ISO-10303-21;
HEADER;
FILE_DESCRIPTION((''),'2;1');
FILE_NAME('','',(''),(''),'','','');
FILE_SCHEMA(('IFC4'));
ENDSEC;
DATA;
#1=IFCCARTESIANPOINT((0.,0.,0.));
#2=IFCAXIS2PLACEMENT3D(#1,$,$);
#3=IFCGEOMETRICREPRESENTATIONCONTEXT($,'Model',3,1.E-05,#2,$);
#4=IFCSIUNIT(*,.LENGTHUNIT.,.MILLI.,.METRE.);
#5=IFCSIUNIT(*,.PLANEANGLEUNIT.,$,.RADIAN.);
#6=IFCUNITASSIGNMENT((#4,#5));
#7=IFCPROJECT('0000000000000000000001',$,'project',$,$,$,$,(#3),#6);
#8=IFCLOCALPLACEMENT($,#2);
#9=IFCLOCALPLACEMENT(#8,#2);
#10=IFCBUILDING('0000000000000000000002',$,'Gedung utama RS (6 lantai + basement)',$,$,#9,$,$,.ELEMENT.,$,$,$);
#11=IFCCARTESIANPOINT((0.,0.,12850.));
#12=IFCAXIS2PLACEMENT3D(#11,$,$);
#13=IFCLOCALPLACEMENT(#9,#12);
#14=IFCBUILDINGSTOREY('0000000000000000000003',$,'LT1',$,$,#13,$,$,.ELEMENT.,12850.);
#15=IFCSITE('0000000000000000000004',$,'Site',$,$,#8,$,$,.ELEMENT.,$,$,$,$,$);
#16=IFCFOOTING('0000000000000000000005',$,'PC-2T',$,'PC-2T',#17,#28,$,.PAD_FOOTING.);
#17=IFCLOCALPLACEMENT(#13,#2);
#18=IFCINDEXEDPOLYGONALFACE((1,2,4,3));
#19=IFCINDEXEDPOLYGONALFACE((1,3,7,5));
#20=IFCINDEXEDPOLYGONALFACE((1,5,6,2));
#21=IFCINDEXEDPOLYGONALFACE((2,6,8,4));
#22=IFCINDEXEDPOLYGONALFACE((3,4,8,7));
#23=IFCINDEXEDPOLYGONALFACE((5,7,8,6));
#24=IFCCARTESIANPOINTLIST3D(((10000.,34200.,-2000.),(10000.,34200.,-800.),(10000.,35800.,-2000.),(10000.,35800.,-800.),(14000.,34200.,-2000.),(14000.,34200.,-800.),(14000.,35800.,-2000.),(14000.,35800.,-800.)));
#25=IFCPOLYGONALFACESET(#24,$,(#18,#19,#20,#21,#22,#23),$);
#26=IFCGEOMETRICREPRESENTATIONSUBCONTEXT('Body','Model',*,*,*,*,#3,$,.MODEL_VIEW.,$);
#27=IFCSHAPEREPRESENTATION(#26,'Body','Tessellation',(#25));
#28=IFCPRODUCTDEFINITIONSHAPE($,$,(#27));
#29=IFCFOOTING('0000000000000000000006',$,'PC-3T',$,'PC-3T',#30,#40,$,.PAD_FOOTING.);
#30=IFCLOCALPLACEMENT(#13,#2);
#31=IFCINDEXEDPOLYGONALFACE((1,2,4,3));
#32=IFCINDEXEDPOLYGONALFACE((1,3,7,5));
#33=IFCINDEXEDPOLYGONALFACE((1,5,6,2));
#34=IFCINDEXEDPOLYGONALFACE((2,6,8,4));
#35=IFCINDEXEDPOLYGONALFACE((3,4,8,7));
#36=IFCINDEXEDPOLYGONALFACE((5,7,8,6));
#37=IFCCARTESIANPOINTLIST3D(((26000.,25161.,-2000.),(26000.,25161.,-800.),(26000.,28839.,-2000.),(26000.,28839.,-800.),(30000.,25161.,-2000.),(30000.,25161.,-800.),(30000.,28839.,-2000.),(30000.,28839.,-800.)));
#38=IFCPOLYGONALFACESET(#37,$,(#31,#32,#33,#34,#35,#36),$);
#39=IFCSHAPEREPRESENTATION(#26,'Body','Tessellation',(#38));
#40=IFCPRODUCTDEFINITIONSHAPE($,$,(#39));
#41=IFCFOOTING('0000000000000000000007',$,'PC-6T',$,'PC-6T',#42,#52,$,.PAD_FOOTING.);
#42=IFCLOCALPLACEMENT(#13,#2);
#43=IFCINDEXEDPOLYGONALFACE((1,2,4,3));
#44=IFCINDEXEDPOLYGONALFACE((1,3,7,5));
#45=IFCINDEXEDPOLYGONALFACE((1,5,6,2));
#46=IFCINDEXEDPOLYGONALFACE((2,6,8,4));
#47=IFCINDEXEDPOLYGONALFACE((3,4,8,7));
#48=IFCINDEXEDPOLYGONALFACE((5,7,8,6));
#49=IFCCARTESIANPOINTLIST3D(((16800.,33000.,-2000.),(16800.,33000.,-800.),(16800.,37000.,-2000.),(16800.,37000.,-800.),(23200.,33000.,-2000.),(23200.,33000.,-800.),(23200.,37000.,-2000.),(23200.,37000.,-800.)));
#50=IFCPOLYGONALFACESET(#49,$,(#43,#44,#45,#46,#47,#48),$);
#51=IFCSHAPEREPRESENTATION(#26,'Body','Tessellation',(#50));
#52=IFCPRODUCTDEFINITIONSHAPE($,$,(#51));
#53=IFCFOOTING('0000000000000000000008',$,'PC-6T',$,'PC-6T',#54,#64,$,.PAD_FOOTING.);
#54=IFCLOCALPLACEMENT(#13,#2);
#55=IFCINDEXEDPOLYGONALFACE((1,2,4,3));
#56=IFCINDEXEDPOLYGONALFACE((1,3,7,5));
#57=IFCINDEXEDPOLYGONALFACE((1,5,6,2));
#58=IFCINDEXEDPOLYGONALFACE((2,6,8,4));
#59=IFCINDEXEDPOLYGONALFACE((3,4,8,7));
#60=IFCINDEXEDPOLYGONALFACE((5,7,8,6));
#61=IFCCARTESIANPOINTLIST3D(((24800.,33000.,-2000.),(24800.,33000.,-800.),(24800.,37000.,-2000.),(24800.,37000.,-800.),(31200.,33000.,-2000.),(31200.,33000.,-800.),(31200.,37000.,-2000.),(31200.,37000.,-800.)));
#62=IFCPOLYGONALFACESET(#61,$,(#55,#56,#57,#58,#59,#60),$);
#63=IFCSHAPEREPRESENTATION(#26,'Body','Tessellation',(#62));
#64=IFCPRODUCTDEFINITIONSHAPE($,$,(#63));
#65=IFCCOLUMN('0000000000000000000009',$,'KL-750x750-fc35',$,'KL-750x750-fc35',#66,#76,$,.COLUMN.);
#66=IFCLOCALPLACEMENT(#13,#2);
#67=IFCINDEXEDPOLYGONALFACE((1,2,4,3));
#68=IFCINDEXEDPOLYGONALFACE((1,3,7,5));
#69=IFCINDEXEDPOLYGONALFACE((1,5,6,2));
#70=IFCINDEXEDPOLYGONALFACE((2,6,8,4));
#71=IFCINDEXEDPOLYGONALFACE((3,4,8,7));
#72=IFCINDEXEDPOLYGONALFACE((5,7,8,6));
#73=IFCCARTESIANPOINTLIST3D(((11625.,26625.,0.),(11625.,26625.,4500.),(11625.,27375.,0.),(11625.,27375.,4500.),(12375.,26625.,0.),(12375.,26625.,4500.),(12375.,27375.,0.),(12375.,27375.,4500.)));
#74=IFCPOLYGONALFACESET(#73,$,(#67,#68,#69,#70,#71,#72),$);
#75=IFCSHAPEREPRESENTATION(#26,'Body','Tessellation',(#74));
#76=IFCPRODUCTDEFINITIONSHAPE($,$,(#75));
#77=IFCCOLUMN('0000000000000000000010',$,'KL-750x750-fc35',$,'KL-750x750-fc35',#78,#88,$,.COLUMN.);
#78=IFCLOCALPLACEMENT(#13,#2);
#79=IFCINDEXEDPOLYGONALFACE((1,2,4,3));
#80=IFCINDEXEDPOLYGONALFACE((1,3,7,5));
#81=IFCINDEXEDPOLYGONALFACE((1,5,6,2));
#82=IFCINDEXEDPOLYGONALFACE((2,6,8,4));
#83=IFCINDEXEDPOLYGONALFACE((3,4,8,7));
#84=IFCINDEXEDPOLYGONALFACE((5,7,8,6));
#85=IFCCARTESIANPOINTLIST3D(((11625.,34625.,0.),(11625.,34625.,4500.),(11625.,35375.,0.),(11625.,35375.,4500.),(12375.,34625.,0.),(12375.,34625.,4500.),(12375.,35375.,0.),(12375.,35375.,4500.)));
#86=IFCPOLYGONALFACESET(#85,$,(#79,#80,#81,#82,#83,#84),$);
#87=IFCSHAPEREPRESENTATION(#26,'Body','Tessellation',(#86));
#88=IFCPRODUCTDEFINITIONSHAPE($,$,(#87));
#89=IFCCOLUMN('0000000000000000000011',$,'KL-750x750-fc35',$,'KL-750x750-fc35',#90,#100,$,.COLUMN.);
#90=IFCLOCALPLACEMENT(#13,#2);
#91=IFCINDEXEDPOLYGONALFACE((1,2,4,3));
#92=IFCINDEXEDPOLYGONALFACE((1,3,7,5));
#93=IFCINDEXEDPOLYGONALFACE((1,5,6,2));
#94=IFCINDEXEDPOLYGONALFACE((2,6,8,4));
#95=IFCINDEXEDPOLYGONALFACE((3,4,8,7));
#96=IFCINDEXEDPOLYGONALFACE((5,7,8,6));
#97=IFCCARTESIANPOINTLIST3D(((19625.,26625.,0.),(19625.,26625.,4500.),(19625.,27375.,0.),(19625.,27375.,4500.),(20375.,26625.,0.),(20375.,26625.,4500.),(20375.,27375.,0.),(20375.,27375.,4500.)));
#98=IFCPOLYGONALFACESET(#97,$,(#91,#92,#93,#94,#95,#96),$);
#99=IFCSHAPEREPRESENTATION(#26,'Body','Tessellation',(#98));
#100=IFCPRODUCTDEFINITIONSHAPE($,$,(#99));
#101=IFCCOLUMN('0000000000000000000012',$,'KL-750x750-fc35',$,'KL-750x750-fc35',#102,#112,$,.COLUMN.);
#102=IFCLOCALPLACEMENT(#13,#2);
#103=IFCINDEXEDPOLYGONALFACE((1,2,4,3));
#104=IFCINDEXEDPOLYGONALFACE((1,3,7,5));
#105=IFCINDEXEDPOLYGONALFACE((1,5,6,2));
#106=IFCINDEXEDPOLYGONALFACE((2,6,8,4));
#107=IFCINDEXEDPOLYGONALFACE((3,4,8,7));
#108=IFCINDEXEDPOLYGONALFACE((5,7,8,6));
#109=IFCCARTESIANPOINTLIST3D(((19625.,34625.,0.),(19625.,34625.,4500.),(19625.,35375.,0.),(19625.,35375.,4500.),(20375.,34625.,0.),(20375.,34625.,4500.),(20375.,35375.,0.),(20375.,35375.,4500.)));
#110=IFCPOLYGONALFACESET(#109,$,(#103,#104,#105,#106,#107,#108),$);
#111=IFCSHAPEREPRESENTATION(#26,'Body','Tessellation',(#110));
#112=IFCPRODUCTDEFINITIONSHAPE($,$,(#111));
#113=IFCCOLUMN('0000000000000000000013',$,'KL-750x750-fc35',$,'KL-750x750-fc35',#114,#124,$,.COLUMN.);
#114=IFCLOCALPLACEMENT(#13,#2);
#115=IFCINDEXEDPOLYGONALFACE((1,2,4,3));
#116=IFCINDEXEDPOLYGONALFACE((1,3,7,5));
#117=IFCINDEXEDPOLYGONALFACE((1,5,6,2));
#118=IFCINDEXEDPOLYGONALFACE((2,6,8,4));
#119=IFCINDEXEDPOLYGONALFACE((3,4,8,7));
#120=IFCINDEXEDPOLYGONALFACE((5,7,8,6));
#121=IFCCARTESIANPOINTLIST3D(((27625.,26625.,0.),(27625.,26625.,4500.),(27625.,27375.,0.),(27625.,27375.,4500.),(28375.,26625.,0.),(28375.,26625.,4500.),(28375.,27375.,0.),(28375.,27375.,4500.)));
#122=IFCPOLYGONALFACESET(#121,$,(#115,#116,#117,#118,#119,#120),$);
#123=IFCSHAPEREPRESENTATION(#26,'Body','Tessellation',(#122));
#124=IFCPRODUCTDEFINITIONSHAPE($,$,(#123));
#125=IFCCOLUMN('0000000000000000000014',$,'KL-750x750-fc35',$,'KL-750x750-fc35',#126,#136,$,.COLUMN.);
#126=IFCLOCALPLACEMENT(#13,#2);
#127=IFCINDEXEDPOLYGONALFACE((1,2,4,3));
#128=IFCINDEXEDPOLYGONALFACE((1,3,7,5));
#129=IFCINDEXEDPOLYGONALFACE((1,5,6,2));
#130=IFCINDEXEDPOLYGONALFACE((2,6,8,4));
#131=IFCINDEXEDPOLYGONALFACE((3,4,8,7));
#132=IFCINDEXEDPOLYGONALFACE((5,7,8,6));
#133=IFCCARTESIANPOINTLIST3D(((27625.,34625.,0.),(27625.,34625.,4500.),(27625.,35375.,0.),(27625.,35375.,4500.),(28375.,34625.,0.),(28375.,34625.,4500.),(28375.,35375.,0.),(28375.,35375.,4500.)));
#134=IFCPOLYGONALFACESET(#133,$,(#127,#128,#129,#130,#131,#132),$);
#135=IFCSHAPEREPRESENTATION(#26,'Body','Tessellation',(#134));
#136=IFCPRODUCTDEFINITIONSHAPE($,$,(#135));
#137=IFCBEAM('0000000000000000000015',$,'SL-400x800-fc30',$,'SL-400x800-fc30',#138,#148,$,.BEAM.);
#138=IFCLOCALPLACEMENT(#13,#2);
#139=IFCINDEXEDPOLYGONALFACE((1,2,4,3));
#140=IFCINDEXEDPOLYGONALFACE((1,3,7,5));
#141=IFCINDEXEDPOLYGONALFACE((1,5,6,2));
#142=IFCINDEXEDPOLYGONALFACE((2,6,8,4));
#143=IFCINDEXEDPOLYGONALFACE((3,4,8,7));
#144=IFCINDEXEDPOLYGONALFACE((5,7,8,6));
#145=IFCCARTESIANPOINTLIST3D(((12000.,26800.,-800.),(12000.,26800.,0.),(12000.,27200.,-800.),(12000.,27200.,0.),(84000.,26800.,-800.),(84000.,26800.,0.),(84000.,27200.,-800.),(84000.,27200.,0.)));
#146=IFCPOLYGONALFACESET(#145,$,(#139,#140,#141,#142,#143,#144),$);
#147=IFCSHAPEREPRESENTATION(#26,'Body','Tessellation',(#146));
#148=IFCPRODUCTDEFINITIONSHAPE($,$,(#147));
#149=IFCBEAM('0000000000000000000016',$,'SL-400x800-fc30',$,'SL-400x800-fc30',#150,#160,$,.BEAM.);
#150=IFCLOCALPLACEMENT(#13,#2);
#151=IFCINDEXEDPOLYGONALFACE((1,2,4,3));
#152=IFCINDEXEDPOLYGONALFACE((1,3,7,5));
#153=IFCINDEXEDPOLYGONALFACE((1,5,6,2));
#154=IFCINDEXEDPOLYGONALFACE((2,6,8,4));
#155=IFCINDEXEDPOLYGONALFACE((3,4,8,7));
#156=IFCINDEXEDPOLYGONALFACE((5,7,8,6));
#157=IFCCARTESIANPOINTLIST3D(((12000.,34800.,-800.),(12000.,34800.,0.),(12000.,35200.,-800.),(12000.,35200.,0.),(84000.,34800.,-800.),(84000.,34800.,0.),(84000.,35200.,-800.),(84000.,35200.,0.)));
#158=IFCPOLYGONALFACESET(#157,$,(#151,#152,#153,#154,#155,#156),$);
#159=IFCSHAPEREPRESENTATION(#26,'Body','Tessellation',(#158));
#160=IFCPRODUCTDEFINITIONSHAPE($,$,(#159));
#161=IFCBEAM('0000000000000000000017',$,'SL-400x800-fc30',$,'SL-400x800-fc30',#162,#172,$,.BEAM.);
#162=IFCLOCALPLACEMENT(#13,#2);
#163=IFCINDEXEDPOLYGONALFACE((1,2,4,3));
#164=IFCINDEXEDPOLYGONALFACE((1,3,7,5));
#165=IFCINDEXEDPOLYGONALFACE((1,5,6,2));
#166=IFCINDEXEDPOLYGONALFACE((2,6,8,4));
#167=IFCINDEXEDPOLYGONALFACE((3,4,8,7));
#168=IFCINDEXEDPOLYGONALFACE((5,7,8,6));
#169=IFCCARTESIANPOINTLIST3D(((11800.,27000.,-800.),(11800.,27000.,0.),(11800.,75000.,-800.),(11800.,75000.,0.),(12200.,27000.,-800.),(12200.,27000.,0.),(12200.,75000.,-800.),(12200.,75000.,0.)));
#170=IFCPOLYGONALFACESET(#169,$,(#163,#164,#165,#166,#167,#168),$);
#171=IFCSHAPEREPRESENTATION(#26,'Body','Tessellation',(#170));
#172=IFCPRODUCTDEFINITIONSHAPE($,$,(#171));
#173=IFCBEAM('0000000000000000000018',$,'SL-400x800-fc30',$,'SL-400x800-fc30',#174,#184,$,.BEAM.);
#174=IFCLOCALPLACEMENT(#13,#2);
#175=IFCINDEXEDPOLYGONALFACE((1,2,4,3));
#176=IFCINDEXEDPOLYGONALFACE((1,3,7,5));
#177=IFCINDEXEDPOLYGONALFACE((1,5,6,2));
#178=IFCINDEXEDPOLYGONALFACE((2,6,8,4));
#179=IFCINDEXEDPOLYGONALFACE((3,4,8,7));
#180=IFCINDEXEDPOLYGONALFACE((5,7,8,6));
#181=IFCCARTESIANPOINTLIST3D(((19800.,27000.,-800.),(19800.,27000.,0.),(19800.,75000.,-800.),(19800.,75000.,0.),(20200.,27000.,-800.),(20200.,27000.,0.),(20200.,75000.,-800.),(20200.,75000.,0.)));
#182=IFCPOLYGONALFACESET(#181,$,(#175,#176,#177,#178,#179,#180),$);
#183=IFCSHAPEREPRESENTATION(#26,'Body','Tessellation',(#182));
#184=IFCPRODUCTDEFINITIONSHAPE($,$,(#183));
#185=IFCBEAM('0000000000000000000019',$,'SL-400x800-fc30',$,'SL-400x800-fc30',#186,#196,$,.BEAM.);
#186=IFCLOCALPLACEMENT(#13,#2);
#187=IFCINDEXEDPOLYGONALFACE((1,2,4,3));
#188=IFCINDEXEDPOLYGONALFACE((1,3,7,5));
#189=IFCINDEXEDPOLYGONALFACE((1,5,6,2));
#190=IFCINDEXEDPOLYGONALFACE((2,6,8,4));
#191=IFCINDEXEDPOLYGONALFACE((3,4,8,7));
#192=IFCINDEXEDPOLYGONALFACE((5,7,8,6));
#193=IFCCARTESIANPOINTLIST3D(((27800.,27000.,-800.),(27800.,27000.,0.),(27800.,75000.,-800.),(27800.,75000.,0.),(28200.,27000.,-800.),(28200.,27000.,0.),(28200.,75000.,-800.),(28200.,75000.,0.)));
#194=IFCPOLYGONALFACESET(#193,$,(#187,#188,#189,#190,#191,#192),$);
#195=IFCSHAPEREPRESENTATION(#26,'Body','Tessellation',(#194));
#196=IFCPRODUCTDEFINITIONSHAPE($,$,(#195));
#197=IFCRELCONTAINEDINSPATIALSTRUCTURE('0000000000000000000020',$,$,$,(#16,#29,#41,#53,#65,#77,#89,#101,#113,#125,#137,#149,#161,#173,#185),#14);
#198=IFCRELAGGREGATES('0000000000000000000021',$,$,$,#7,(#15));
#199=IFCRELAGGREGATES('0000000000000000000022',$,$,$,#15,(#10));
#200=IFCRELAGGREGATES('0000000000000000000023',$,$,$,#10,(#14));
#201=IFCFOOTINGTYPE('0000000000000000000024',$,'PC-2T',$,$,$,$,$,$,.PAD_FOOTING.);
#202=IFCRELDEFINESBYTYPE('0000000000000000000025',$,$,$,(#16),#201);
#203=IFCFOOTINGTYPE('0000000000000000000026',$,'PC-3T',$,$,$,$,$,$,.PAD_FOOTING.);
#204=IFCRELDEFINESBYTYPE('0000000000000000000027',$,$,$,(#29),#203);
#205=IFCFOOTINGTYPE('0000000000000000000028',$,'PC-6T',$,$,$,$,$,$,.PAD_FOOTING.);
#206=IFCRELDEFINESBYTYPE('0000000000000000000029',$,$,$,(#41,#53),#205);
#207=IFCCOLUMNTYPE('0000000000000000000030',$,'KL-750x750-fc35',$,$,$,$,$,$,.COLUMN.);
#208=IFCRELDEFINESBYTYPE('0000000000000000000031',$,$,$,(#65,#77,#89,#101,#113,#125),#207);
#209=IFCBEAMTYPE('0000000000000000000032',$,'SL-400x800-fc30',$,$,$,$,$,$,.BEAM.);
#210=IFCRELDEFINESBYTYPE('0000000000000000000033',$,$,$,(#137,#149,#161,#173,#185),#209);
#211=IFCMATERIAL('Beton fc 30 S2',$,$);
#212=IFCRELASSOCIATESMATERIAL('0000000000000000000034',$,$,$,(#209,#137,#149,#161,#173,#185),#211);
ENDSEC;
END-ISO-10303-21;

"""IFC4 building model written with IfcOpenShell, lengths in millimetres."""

from ifc_helpers import new_model, si_unit, frame, origin, origin_2d, place, context, subcontext, project, spatial, rectangle, extrude, material, material_profile, profile_set, profile_usage, type_object, element, save


model = new_model("IFC4")

# Units and contexts
model_context = context("Model", 3, precision=1e-05, world=origin())
body_context = subcontext(model_context, "Body", "Model", "MODEL_VIEW")
ifc_project = project(units=[si_unit("LENGTHUNIT", "METRE", prefix="MILLI"), si_unit("PLANEANGLEUNIT", "RADIAN")], contexts=[model_context])

# Site, building, storey
site_placement = place(None, origin())
site = spatial("IfcSite", under=ifc_project, at=site_placement, Name="Site", CompositionType="ELEMENT")
building_placement = place(site_placement, origin())
building = spatial("IfcBuilding", under=site, at=building_placement, Name="Gedung utama RS (6 lantai + basement)", CompositionType="ELEMENT")
storey_placement = place(building_placement, frame((0.0, 0.0, 12850.0)))
storey = spatial("IfcBuildingStorey", under=building, at=storey_placement, Name="LT1", CompositionType="ELEMENT", Elevation=12850.0)

# Footings
ifc_material_profile_1 = material_profile(None, rectangle(XDim=4000.0, YDim=1600.0, at=origin_2d()), Name="PC-2T")
ifc_profile_set_1 = profile_set([ifc_material_profile_1], Name="PC-2T")
ifc_profile_usage_1 = profile_usage(ifc_profile_set_1, cardinal=5)
footing_type_1 = type_object("IfcFootingType", Name="PC-2T", PredefinedType="PAD_FOOTING", material=ifc_profile_set_1)
footing_1_placement = place(storey_placement, frame((12000.0, 35000.0, -2000.0), z_axis=(0.0, 0.0, 1.0), x_axis=(1.0, 0.0, 0.0)))
element("IfcFooting", 1, at=footing_1_placement, inside=storey, type_object=footing_type_1, material=ifc_profile_usage_1, Name="PC-2T", ObjectType="PC-2T", PredefinedType="PAD_FOOTING", context=body_context, shape_type="SweptSolid", body=[
    extrude(rectangle(XDim=4000.0, YDim=1600.0, at=origin_2d()), origin(), (0.0, 0.0, 1.0), 1200.0),
])
ifc_material_profile_2 = material_profile(None, rectangle(XDim=4000.0, YDim=3678.0, at=origin_2d()), Name="PC-3T")
ifc_profile_set_2 = profile_set([ifc_material_profile_2], Name="PC-3T")
ifc_profile_usage_2 = profile_usage(ifc_profile_set_2, cardinal=5)
footing_type_2 = type_object("IfcFootingType", Name="PC-3T", PredefinedType="PAD_FOOTING", material=ifc_profile_set_2)
footing_2_placement = place(storey_placement, frame((28000.0, 27000.0, -2000.0), z_axis=(0.0, 0.0, 1.0), x_axis=(1.0, 0.0, 0.0)))
element("IfcFooting", 2, at=footing_2_placement, inside=storey, type_object=footing_type_2, material=ifc_profile_usage_2, Name="PC-3T", ObjectType="PC-3T", PredefinedType="PAD_FOOTING", context=body_context, shape_type="SweptSolid", body=[
    extrude(rectangle(XDim=4000.0, YDim=3678.0, at=origin_2d()), origin(), (0.0, 0.0, 1.0), 1200.0),
])
ifc_material_profile_3 = material_profile(None, rectangle(XDim=6400.0, YDim=4000.0, at=origin_2d()), Name="PC-6T")
ifc_profile_set_3 = profile_set([ifc_material_profile_3], Name="PC-6T")
ifc_profile_usage_3 = profile_usage(ifc_profile_set_3, cardinal=5)
footing_type_3 = type_object("IfcFootingType", Name="PC-6T", PredefinedType="PAD_FOOTING", material=ifc_profile_set_3)
for number, where, z_axis, x_axis, name in (
    (3, (20000.0, 35000.0, -2000.0), (0.0, 0.0, 1.0), (1.0, 0.0, 0.0), "PC-6T"),
    (4, (28000.0, 35000.0, -2000.0), (0.0, 0.0, 1.0), (1.0, 0.0, 0.0), "PC-6T"),
):
    element("IfcFooting", number, at=place(storey_placement, frame(where, z_axis=z_axis, x_axis=x_axis)), inside=storey, type_object=footing_type_3, material=ifc_profile_usage_3, Name=name, ObjectType="PC-6T", PredefinedType="PAD_FOOTING", context=body_context, shape_type="SweptSolid", body=[
        extrude(rectangle(XDim=6400.0, YDim=4000.0, at=origin_2d()), origin(), (0.0, 0.0, 1.0), 1200.0),
    ])

# Columns
ifc_material_profile_4 = material_profile(None, rectangle(XDim=750.0, YDim=750.0, at=origin_2d()), Name="KL-750x750-fc35")
ifc_profile_set_4 = profile_set([ifc_material_profile_4], Name="KL-750x750-fc35")
ifc_profile_usage_4 = profile_usage(ifc_profile_set_4, cardinal=5)
column_type = type_object("IfcColumnType", Name="KL-750x750-fc35", PredefinedType="COLUMN", material=ifc_profile_set_4)
for number, where, z_axis, x_axis, name in (
    (5, (12000.0, 27000.0, 0.0), (0.0, 0.0, 1.0), (1.0, 0.0, 0.0), "KL-750x750-fc35"),
    (6, (12000.0, 35000.0, 0.0), (0.0, 0.0, 1.0), (1.0, 0.0, 0.0), "KL-750x750-fc35"),
    (7, (20000.0, 27000.0, 0.0), (0.0, 0.0, 1.0), (1.0, 0.0, 0.0), "KL-750x750-fc35"),
    (8, (20000.0, 35000.0, 0.0), (0.0, 0.0, 1.0), (1.0, 0.0, 0.0), "KL-750x750-fc35"),
    (9, (28000.0, 27000.0, 0.0), (0.0, 0.0, 1.0), (1.0, 0.0, 0.0), "KL-750x750-fc35"),
    (10, (28000.0, 35000.0, 0.0), (0.0, 0.0, 1.0), (1.0, 0.0, 0.0), "KL-750x750-fc35"),
):
    element("IfcColumn", number, at=place(storey_placement, frame(where, z_axis=z_axis, x_axis=x_axis)), inside=storey, type_object=column_type, material=ifc_profile_usage_4, Name=name, ObjectType="KL-750x750-fc35", PredefinedType="COLUMN", context=body_context, shape_type="SweptSolid", body=[
        extrude(rectangle(XDim=750.0, YDim=750.0, at=origin_2d()), origin(), (0.0, 0.0, 1.0), 4500.0),
    ])

# Beams
ifc_material_1 = material(Name="Beton fc 30 S2")
ifc_material_profile_5 = material_profile(ifc_material_1, rectangle(XDim=400.0, YDim=800.0, at=origin_2d()), Name="SL-400x800-fc30")
ifc_profile_set_5 = profile_set([ifc_material_profile_5], Name="SL-400x800-fc30")
ifc_profile_usage_5 = profile_usage(ifc_profile_set_5, cardinal=8)
beam_type = type_object("IfcBeamType", Name="SL-400x800-fc30", PredefinedType="BEAM", material=ifc_profile_set_5)
for number, where, name in (
    (11, (12000.0, 27000.0, -400.0), "SL-400x800-fc30"),
    (12, (12000.0, 35000.0, -400.0), "SL-400x800-fc30"),
):
    element("IfcBeam", number, at=place(storey_placement, frame(where)), inside=storey, type_object=beam_type, material=ifc_profile_usage_5, Name=name, ObjectType="SL-400x800-fc30", PredefinedType="BEAM", context=body_context, shape_type="SweptSolid", body=[
        extrude(rectangle(XDim=400.0, YDim=800.0, at=origin_2d()), frame((0.0, 0.0, 0.0), z_axis=(1.0, 0.0, 0.0), x_axis=(0.0, 1.0, 0.0)), (0.0, 0.0, 1.0), 72000.0),
    ])
for number, where, name in (
    (13, (12000.0, 27000.0, -400.0), "SL-400x800-fc30"),
    (14, (20000.0, 27000.0, -400.0), "SL-400x800-fc30"),
    (15, (28000.0, 27000.0, -400.0), "SL-400x800-fc30"),
):
    element("IfcBeam", number, at=place(storey_placement, frame(where)), inside=storey, type_object=beam_type, material=ifc_profile_usage_5, Name=name, ObjectType="SL-400x800-fc30", PredefinedType="BEAM", context=body_context, shape_type="SweptSolid", body=[
        extrude(rectangle(XDim=400.0, YDim=800.0, at=origin_2d()), frame((0.0, 0.0, 0.0), z_axis=(0.0, 1.0, 0.0), x_axis=(-1.0, 0.0, 0.0)), (0.0, 0.0, 1.0), 48000.0),
    ])

save(model, "model.ifc")
